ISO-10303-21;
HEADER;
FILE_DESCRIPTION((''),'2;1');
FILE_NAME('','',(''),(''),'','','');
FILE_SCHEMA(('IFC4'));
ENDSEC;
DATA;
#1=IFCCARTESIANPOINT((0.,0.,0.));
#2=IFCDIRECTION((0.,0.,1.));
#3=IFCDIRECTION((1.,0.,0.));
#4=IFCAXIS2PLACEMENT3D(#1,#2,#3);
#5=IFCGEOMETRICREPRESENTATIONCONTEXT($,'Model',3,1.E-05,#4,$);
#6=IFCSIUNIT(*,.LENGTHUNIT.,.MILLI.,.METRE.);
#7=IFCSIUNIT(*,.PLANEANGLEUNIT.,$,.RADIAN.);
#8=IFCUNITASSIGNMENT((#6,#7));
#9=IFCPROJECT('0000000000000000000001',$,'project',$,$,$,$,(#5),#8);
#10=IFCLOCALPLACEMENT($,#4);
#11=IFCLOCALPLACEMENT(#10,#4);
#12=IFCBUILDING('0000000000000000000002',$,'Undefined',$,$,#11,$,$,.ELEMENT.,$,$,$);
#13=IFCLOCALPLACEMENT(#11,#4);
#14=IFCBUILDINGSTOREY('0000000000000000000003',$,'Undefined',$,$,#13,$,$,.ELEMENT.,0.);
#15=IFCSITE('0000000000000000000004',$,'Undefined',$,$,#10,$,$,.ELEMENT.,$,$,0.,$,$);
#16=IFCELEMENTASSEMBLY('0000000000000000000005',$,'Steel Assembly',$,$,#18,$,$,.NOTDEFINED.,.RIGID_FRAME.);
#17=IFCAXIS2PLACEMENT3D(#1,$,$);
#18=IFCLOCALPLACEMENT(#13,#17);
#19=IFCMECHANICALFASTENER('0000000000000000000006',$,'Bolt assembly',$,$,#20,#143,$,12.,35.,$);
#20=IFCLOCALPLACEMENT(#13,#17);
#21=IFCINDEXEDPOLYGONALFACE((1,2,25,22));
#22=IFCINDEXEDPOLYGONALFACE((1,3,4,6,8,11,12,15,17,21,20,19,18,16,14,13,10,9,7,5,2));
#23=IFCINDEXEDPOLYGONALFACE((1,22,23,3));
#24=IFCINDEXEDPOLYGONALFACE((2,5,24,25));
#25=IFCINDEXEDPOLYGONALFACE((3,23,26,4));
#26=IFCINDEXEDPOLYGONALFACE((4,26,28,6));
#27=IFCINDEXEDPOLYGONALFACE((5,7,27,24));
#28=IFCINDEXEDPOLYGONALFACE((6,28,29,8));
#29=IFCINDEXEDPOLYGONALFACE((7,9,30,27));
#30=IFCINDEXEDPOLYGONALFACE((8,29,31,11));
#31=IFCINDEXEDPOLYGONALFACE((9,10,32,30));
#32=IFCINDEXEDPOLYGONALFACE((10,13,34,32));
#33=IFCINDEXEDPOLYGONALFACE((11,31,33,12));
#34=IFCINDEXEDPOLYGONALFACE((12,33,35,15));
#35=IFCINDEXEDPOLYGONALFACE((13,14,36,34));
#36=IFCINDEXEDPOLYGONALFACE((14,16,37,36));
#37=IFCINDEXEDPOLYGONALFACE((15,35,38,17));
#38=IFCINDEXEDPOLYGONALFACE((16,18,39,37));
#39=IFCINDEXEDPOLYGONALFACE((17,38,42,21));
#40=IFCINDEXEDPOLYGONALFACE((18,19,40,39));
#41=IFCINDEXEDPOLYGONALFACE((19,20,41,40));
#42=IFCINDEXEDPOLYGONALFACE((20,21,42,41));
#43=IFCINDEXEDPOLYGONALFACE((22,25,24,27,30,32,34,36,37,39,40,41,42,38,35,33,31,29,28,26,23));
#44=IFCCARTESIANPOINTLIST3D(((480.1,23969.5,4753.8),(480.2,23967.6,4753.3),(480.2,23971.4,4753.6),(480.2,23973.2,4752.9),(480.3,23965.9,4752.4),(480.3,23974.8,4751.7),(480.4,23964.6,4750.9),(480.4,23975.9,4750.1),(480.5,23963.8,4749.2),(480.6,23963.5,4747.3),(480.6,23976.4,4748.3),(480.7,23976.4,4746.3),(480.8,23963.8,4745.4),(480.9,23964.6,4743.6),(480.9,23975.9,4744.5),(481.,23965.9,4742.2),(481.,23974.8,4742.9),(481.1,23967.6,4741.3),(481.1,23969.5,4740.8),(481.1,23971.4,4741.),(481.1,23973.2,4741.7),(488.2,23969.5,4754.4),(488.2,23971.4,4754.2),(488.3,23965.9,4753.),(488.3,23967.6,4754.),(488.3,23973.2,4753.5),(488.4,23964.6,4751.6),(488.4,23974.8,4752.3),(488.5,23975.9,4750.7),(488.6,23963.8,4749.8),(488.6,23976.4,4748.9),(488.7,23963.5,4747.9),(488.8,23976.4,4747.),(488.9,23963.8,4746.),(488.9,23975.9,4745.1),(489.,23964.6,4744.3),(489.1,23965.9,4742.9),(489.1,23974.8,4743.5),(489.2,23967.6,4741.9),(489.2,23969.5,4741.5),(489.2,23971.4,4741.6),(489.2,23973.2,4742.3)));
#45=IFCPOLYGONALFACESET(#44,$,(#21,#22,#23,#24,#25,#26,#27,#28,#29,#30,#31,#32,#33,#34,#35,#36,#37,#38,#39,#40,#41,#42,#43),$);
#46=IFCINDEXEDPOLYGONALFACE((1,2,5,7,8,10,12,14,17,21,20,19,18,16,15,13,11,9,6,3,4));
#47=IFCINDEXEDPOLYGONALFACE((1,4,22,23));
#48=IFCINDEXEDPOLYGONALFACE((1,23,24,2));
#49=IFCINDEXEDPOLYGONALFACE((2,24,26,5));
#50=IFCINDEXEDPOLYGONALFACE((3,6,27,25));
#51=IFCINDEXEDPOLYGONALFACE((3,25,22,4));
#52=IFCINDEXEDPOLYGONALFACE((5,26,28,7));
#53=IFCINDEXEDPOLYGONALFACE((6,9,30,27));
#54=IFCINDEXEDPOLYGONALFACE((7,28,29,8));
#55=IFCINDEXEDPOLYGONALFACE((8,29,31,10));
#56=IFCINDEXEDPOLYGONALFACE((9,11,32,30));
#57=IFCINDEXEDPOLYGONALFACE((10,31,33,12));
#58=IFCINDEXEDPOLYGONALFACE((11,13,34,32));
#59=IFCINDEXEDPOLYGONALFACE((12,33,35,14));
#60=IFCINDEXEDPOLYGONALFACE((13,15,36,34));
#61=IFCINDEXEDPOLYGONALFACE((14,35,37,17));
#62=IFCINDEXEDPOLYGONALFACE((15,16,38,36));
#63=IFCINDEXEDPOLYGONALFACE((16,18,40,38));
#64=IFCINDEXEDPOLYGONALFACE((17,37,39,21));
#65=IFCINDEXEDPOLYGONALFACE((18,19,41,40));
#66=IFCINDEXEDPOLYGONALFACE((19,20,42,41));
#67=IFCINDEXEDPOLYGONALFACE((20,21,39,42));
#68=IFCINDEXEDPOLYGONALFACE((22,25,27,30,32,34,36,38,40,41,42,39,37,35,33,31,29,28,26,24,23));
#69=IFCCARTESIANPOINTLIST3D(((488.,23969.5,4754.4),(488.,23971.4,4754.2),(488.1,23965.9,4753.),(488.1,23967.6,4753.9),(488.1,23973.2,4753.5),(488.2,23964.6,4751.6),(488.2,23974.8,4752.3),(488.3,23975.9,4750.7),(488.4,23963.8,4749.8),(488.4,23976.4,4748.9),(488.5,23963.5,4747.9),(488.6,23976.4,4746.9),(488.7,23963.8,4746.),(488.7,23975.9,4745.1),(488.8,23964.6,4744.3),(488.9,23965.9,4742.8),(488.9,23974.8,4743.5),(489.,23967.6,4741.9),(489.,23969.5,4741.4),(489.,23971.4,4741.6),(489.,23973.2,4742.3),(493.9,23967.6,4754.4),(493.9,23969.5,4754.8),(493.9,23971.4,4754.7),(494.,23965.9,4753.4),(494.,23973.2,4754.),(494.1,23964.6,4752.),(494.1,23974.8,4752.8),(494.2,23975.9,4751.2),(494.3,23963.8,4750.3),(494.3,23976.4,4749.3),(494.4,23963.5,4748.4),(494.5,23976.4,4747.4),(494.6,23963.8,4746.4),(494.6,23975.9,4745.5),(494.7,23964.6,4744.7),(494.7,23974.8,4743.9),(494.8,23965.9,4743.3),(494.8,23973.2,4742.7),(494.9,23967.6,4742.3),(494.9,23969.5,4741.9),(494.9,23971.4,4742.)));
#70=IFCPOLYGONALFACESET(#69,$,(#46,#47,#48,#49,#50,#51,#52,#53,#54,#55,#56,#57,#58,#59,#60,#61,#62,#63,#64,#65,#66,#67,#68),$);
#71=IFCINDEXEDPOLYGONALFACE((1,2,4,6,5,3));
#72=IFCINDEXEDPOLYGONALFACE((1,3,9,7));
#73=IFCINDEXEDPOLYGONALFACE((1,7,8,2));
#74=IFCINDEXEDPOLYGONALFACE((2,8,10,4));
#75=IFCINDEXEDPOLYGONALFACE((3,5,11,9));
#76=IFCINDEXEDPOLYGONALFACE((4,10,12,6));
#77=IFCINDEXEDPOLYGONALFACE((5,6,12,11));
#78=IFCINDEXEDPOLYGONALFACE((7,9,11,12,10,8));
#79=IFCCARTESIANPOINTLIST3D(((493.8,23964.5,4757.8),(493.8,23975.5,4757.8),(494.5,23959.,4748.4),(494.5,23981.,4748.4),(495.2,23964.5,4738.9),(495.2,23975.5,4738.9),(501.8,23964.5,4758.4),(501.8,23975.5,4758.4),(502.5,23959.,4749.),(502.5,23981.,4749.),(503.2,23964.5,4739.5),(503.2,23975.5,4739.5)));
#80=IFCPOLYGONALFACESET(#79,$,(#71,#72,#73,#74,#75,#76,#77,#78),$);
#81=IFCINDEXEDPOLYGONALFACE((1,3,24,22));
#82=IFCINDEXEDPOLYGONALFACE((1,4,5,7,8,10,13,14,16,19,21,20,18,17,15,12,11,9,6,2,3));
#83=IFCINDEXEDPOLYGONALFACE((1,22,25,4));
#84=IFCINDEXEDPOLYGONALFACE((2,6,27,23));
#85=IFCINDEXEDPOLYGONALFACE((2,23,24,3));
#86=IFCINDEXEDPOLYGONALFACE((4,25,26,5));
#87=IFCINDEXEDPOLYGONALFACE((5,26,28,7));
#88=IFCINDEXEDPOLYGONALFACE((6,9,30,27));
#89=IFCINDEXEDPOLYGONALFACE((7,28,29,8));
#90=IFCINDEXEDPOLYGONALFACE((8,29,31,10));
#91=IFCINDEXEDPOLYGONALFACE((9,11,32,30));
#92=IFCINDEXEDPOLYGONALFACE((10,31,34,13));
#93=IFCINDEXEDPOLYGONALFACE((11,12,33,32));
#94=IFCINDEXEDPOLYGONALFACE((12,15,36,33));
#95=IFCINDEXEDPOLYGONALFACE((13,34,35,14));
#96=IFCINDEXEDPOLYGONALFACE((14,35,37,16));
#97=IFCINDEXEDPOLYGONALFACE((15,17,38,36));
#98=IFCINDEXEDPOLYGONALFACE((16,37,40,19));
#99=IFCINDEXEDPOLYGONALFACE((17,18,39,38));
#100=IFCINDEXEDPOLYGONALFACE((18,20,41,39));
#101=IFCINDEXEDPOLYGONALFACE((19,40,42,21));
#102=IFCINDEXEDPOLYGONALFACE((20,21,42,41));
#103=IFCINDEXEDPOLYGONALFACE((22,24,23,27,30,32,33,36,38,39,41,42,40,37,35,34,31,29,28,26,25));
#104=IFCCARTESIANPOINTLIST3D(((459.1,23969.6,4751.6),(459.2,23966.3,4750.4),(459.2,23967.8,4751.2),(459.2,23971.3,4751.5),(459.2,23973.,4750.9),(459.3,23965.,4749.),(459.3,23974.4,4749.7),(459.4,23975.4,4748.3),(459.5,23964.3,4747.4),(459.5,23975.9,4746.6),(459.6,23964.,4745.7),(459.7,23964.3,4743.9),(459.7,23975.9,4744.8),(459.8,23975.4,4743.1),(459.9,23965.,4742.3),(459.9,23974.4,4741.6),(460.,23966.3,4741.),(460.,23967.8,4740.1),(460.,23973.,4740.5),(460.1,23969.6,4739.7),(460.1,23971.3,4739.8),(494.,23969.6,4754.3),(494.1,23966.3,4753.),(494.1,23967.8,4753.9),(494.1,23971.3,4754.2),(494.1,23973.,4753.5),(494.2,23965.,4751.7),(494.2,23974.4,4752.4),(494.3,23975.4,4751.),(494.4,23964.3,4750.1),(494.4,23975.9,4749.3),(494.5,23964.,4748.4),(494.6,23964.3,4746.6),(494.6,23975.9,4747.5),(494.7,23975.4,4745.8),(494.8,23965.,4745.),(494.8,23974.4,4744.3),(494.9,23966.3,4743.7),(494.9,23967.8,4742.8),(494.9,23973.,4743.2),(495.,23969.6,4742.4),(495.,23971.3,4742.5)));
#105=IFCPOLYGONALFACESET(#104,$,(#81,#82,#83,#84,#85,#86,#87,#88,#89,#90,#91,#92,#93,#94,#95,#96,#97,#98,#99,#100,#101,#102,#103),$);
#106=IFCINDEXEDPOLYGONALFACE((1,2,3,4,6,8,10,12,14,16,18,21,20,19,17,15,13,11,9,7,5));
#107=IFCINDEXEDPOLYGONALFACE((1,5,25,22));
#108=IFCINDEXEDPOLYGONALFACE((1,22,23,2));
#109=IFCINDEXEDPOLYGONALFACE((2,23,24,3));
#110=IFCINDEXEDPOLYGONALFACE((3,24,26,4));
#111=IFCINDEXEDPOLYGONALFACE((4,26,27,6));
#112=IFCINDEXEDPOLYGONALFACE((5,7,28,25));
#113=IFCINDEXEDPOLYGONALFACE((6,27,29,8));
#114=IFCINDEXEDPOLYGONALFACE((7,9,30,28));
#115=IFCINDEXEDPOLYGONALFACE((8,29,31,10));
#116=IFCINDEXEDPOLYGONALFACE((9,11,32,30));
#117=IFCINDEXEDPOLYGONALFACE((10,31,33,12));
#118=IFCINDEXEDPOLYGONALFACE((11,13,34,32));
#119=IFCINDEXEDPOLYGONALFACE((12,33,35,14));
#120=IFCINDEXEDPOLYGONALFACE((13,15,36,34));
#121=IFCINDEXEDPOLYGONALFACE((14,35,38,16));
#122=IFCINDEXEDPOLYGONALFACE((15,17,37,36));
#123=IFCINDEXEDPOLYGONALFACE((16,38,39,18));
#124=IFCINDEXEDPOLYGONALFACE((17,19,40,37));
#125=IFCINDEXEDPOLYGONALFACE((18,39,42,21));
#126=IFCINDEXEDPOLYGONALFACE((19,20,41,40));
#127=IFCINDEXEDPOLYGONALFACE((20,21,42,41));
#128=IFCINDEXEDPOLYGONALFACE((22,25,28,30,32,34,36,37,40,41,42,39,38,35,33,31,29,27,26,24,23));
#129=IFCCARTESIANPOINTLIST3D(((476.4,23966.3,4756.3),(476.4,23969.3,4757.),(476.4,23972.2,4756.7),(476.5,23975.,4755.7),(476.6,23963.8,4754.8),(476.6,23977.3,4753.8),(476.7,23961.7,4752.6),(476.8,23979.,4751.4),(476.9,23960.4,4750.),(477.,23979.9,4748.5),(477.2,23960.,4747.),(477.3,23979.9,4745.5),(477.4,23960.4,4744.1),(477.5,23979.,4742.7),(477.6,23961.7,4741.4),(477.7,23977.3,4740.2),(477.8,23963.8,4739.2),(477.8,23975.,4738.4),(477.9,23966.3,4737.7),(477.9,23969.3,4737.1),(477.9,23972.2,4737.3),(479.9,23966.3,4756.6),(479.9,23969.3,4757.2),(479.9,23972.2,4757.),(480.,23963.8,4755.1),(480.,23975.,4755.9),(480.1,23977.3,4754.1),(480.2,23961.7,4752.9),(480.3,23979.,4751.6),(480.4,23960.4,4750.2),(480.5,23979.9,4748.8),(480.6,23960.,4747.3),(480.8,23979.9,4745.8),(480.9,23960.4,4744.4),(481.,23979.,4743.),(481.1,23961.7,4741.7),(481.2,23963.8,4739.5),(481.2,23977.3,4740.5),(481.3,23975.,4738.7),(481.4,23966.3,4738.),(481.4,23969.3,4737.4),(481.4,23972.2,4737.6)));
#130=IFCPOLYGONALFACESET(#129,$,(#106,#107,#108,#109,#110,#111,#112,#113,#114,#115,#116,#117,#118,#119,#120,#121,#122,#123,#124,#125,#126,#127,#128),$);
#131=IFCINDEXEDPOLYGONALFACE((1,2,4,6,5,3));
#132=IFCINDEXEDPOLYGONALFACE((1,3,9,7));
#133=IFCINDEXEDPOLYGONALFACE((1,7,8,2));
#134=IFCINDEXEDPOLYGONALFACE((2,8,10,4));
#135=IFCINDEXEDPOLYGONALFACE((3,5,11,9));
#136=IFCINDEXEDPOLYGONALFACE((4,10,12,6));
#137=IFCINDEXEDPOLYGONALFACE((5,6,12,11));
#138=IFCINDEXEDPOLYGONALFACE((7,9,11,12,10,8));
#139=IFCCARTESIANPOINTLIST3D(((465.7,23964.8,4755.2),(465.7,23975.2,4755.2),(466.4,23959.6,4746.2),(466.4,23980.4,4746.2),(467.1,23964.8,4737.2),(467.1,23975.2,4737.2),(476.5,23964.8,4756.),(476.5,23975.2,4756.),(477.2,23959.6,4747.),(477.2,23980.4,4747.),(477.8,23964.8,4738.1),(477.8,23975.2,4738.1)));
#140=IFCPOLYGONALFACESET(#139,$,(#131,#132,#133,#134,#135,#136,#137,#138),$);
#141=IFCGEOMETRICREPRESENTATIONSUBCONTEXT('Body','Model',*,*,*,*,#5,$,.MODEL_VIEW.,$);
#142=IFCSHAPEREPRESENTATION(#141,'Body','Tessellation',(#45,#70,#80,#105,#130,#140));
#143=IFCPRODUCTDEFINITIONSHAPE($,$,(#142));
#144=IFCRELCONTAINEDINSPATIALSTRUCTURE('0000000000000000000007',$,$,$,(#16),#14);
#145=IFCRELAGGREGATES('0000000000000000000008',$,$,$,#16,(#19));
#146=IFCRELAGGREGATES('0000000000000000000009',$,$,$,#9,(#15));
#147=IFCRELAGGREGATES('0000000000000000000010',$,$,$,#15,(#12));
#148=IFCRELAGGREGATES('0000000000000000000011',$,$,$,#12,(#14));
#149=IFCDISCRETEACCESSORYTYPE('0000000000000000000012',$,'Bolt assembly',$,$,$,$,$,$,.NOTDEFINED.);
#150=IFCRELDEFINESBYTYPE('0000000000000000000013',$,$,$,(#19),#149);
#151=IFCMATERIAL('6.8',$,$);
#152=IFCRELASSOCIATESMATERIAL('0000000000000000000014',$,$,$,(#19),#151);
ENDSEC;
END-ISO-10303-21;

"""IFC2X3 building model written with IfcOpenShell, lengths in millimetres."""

from ifc_helpers import new_model, si_unit, frame, origin_with_axes, origin_2d_with_axis, place, context, subcontext, project, spatial, polyline, circle, outline, extrude, source, transform, mapped, material, type_object, element, aggregate, save


model = new_model("IFC2X3")

# Units and contexts
model_context = context("Model", 3, precision=1e-05, world=origin_with_axes())
body_context = subcontext(model_context, "Body", "Model", "MODEL_VIEW")
ifc_project = project(units=[si_unit("LENGTHUNIT", "METRE", prefix="MILLI"), si_unit("PLANEANGLEUNIT", "RADIAN")], contexts=[model_context])

# Site, building, storey
site_placement = place(None, origin_with_axes())
site = spatial("IfcSite", under=ifc_project, at=site_placement, Name="Undefined", CompositionType="ELEMENT", RefElevation=0.0)
building_placement = place(site_placement, origin_with_axes())
building = spatial("IfcBuilding", under=site, at=building_placement, Name="Undefined", CompositionType="ELEMENT")
storey_placement = place(building_placement, origin_with_axes())
storey = spatial("IfcBuildingStorey", under=building, at=storey_placement, Name="Undefined", CompositionType="ELEMENT", Elevation=0.0)

# Element assembly, mechanical fastener
assembly_1_placement = place(storey_placement, origin_with_axes())
assembly_1 = element("IfcElementAssembly", 1, at=assembly_1_placement, inside=storey, Name="Steel Assembly", AssemblyPlace="NOTDEFINED", PredefinedType="RIGID_FRAME")
ifc_material_1 = material(Name="6.8")
discrete_accessory_type_1 = type_object("IfcDiscreteAccessoryType", Name="Bolt assembly")
shared_shape_1 = source(origin_with_axes(), body_context, "Body", "SweptSolid", [
    extrude(circle(Radius=6.5, at=origin_2d_with_axis()), frame((0.0, 2.9, 0.0), z_axis=(0.0, 1.0, 0.0), x_axis=(1.0, 0.0, 0.0)), (0.0, 0.0, 1.0), 8.1),
    extrude(circle(Radius=6.5, at=origin_2d_with_axis()), frame((0.0, -2.9, 0.0), z_axis=(0.0, 1.0, 0.0), x_axis=(1.0, 0.0, 0.0)), (0.0, 0.0, 1.0), 5.9),
    extrude(outline(polyline([(11.0, 0.0), (5.5, 9.5), (-5.5, 9.5), (-11.0, 0.0), (-5.5, -9.5), (5.5, -9.5), (11.0, 0.0)])), frame((0.0, -11.0, 0.0), z_axis=(0.0, 1.0, 0.0), x_axis=(1.0, 0.0, 0.0)), (0.0, 0.0, 1.0), 8.0),
    extrude(circle(Radius=6.0, at=origin_2d_with_axis()), frame((0.0, -3.0, 0.0), z_axis=(0.0, 1.0, 0.0), x_axis=(1.0, 0.0, 0.0)), (0.0, 0.0, 1.0), 35.0),
    extrude(circle(Radius=10.0, at=origin_2d_with_axis()), frame((0.0, 11.0, 0.0), z_axis=(0.0, 1.0, 0.0), x_axis=(1.0, 0.0, 0.0)), (0.0, 0.0, 1.0), 3.5),
    extrude(outline(polyline([(10.4, 0.0), (5.2, 9.0), (-5.2, 9.0), (-10.4, 0.0), (-5.2, -9.0), (5.2, -9.0), (10.4, 0.0)])), frame((0.0, 14.5, 0.0), z_axis=(0.0, 1.0, 0.0), x_axis=(1.0, 0.0, 0.0)), (0.0, 0.0, 1.0), 10.8),
])
mechanical_fastener_1_placement = place(assembly_1_placement, frame((491.6, 23970.0, 4748.1), z_axis=(0.076696, 0.0, -0.997054), x_axis=(0.0, -1.0, 0.0)))
mechanical_fastener_1 = element("IfcMechanicalFastener", 2, at=mechanical_fastener_1_placement, type_object=discrete_accessory_type_1, material=ifc_material_1, Name="Bolt assembly", NominalDiameter=12.0, NominalLength=35.0, context=body_context, shape_type="MappedRepresentation", body=[
    mapped(shared_shape_1, transform((0.0, 0.0, 0.0))),
])

aggregate(assembly_1, [mechanical_fastener_1])

save(model, "model.ifc")
